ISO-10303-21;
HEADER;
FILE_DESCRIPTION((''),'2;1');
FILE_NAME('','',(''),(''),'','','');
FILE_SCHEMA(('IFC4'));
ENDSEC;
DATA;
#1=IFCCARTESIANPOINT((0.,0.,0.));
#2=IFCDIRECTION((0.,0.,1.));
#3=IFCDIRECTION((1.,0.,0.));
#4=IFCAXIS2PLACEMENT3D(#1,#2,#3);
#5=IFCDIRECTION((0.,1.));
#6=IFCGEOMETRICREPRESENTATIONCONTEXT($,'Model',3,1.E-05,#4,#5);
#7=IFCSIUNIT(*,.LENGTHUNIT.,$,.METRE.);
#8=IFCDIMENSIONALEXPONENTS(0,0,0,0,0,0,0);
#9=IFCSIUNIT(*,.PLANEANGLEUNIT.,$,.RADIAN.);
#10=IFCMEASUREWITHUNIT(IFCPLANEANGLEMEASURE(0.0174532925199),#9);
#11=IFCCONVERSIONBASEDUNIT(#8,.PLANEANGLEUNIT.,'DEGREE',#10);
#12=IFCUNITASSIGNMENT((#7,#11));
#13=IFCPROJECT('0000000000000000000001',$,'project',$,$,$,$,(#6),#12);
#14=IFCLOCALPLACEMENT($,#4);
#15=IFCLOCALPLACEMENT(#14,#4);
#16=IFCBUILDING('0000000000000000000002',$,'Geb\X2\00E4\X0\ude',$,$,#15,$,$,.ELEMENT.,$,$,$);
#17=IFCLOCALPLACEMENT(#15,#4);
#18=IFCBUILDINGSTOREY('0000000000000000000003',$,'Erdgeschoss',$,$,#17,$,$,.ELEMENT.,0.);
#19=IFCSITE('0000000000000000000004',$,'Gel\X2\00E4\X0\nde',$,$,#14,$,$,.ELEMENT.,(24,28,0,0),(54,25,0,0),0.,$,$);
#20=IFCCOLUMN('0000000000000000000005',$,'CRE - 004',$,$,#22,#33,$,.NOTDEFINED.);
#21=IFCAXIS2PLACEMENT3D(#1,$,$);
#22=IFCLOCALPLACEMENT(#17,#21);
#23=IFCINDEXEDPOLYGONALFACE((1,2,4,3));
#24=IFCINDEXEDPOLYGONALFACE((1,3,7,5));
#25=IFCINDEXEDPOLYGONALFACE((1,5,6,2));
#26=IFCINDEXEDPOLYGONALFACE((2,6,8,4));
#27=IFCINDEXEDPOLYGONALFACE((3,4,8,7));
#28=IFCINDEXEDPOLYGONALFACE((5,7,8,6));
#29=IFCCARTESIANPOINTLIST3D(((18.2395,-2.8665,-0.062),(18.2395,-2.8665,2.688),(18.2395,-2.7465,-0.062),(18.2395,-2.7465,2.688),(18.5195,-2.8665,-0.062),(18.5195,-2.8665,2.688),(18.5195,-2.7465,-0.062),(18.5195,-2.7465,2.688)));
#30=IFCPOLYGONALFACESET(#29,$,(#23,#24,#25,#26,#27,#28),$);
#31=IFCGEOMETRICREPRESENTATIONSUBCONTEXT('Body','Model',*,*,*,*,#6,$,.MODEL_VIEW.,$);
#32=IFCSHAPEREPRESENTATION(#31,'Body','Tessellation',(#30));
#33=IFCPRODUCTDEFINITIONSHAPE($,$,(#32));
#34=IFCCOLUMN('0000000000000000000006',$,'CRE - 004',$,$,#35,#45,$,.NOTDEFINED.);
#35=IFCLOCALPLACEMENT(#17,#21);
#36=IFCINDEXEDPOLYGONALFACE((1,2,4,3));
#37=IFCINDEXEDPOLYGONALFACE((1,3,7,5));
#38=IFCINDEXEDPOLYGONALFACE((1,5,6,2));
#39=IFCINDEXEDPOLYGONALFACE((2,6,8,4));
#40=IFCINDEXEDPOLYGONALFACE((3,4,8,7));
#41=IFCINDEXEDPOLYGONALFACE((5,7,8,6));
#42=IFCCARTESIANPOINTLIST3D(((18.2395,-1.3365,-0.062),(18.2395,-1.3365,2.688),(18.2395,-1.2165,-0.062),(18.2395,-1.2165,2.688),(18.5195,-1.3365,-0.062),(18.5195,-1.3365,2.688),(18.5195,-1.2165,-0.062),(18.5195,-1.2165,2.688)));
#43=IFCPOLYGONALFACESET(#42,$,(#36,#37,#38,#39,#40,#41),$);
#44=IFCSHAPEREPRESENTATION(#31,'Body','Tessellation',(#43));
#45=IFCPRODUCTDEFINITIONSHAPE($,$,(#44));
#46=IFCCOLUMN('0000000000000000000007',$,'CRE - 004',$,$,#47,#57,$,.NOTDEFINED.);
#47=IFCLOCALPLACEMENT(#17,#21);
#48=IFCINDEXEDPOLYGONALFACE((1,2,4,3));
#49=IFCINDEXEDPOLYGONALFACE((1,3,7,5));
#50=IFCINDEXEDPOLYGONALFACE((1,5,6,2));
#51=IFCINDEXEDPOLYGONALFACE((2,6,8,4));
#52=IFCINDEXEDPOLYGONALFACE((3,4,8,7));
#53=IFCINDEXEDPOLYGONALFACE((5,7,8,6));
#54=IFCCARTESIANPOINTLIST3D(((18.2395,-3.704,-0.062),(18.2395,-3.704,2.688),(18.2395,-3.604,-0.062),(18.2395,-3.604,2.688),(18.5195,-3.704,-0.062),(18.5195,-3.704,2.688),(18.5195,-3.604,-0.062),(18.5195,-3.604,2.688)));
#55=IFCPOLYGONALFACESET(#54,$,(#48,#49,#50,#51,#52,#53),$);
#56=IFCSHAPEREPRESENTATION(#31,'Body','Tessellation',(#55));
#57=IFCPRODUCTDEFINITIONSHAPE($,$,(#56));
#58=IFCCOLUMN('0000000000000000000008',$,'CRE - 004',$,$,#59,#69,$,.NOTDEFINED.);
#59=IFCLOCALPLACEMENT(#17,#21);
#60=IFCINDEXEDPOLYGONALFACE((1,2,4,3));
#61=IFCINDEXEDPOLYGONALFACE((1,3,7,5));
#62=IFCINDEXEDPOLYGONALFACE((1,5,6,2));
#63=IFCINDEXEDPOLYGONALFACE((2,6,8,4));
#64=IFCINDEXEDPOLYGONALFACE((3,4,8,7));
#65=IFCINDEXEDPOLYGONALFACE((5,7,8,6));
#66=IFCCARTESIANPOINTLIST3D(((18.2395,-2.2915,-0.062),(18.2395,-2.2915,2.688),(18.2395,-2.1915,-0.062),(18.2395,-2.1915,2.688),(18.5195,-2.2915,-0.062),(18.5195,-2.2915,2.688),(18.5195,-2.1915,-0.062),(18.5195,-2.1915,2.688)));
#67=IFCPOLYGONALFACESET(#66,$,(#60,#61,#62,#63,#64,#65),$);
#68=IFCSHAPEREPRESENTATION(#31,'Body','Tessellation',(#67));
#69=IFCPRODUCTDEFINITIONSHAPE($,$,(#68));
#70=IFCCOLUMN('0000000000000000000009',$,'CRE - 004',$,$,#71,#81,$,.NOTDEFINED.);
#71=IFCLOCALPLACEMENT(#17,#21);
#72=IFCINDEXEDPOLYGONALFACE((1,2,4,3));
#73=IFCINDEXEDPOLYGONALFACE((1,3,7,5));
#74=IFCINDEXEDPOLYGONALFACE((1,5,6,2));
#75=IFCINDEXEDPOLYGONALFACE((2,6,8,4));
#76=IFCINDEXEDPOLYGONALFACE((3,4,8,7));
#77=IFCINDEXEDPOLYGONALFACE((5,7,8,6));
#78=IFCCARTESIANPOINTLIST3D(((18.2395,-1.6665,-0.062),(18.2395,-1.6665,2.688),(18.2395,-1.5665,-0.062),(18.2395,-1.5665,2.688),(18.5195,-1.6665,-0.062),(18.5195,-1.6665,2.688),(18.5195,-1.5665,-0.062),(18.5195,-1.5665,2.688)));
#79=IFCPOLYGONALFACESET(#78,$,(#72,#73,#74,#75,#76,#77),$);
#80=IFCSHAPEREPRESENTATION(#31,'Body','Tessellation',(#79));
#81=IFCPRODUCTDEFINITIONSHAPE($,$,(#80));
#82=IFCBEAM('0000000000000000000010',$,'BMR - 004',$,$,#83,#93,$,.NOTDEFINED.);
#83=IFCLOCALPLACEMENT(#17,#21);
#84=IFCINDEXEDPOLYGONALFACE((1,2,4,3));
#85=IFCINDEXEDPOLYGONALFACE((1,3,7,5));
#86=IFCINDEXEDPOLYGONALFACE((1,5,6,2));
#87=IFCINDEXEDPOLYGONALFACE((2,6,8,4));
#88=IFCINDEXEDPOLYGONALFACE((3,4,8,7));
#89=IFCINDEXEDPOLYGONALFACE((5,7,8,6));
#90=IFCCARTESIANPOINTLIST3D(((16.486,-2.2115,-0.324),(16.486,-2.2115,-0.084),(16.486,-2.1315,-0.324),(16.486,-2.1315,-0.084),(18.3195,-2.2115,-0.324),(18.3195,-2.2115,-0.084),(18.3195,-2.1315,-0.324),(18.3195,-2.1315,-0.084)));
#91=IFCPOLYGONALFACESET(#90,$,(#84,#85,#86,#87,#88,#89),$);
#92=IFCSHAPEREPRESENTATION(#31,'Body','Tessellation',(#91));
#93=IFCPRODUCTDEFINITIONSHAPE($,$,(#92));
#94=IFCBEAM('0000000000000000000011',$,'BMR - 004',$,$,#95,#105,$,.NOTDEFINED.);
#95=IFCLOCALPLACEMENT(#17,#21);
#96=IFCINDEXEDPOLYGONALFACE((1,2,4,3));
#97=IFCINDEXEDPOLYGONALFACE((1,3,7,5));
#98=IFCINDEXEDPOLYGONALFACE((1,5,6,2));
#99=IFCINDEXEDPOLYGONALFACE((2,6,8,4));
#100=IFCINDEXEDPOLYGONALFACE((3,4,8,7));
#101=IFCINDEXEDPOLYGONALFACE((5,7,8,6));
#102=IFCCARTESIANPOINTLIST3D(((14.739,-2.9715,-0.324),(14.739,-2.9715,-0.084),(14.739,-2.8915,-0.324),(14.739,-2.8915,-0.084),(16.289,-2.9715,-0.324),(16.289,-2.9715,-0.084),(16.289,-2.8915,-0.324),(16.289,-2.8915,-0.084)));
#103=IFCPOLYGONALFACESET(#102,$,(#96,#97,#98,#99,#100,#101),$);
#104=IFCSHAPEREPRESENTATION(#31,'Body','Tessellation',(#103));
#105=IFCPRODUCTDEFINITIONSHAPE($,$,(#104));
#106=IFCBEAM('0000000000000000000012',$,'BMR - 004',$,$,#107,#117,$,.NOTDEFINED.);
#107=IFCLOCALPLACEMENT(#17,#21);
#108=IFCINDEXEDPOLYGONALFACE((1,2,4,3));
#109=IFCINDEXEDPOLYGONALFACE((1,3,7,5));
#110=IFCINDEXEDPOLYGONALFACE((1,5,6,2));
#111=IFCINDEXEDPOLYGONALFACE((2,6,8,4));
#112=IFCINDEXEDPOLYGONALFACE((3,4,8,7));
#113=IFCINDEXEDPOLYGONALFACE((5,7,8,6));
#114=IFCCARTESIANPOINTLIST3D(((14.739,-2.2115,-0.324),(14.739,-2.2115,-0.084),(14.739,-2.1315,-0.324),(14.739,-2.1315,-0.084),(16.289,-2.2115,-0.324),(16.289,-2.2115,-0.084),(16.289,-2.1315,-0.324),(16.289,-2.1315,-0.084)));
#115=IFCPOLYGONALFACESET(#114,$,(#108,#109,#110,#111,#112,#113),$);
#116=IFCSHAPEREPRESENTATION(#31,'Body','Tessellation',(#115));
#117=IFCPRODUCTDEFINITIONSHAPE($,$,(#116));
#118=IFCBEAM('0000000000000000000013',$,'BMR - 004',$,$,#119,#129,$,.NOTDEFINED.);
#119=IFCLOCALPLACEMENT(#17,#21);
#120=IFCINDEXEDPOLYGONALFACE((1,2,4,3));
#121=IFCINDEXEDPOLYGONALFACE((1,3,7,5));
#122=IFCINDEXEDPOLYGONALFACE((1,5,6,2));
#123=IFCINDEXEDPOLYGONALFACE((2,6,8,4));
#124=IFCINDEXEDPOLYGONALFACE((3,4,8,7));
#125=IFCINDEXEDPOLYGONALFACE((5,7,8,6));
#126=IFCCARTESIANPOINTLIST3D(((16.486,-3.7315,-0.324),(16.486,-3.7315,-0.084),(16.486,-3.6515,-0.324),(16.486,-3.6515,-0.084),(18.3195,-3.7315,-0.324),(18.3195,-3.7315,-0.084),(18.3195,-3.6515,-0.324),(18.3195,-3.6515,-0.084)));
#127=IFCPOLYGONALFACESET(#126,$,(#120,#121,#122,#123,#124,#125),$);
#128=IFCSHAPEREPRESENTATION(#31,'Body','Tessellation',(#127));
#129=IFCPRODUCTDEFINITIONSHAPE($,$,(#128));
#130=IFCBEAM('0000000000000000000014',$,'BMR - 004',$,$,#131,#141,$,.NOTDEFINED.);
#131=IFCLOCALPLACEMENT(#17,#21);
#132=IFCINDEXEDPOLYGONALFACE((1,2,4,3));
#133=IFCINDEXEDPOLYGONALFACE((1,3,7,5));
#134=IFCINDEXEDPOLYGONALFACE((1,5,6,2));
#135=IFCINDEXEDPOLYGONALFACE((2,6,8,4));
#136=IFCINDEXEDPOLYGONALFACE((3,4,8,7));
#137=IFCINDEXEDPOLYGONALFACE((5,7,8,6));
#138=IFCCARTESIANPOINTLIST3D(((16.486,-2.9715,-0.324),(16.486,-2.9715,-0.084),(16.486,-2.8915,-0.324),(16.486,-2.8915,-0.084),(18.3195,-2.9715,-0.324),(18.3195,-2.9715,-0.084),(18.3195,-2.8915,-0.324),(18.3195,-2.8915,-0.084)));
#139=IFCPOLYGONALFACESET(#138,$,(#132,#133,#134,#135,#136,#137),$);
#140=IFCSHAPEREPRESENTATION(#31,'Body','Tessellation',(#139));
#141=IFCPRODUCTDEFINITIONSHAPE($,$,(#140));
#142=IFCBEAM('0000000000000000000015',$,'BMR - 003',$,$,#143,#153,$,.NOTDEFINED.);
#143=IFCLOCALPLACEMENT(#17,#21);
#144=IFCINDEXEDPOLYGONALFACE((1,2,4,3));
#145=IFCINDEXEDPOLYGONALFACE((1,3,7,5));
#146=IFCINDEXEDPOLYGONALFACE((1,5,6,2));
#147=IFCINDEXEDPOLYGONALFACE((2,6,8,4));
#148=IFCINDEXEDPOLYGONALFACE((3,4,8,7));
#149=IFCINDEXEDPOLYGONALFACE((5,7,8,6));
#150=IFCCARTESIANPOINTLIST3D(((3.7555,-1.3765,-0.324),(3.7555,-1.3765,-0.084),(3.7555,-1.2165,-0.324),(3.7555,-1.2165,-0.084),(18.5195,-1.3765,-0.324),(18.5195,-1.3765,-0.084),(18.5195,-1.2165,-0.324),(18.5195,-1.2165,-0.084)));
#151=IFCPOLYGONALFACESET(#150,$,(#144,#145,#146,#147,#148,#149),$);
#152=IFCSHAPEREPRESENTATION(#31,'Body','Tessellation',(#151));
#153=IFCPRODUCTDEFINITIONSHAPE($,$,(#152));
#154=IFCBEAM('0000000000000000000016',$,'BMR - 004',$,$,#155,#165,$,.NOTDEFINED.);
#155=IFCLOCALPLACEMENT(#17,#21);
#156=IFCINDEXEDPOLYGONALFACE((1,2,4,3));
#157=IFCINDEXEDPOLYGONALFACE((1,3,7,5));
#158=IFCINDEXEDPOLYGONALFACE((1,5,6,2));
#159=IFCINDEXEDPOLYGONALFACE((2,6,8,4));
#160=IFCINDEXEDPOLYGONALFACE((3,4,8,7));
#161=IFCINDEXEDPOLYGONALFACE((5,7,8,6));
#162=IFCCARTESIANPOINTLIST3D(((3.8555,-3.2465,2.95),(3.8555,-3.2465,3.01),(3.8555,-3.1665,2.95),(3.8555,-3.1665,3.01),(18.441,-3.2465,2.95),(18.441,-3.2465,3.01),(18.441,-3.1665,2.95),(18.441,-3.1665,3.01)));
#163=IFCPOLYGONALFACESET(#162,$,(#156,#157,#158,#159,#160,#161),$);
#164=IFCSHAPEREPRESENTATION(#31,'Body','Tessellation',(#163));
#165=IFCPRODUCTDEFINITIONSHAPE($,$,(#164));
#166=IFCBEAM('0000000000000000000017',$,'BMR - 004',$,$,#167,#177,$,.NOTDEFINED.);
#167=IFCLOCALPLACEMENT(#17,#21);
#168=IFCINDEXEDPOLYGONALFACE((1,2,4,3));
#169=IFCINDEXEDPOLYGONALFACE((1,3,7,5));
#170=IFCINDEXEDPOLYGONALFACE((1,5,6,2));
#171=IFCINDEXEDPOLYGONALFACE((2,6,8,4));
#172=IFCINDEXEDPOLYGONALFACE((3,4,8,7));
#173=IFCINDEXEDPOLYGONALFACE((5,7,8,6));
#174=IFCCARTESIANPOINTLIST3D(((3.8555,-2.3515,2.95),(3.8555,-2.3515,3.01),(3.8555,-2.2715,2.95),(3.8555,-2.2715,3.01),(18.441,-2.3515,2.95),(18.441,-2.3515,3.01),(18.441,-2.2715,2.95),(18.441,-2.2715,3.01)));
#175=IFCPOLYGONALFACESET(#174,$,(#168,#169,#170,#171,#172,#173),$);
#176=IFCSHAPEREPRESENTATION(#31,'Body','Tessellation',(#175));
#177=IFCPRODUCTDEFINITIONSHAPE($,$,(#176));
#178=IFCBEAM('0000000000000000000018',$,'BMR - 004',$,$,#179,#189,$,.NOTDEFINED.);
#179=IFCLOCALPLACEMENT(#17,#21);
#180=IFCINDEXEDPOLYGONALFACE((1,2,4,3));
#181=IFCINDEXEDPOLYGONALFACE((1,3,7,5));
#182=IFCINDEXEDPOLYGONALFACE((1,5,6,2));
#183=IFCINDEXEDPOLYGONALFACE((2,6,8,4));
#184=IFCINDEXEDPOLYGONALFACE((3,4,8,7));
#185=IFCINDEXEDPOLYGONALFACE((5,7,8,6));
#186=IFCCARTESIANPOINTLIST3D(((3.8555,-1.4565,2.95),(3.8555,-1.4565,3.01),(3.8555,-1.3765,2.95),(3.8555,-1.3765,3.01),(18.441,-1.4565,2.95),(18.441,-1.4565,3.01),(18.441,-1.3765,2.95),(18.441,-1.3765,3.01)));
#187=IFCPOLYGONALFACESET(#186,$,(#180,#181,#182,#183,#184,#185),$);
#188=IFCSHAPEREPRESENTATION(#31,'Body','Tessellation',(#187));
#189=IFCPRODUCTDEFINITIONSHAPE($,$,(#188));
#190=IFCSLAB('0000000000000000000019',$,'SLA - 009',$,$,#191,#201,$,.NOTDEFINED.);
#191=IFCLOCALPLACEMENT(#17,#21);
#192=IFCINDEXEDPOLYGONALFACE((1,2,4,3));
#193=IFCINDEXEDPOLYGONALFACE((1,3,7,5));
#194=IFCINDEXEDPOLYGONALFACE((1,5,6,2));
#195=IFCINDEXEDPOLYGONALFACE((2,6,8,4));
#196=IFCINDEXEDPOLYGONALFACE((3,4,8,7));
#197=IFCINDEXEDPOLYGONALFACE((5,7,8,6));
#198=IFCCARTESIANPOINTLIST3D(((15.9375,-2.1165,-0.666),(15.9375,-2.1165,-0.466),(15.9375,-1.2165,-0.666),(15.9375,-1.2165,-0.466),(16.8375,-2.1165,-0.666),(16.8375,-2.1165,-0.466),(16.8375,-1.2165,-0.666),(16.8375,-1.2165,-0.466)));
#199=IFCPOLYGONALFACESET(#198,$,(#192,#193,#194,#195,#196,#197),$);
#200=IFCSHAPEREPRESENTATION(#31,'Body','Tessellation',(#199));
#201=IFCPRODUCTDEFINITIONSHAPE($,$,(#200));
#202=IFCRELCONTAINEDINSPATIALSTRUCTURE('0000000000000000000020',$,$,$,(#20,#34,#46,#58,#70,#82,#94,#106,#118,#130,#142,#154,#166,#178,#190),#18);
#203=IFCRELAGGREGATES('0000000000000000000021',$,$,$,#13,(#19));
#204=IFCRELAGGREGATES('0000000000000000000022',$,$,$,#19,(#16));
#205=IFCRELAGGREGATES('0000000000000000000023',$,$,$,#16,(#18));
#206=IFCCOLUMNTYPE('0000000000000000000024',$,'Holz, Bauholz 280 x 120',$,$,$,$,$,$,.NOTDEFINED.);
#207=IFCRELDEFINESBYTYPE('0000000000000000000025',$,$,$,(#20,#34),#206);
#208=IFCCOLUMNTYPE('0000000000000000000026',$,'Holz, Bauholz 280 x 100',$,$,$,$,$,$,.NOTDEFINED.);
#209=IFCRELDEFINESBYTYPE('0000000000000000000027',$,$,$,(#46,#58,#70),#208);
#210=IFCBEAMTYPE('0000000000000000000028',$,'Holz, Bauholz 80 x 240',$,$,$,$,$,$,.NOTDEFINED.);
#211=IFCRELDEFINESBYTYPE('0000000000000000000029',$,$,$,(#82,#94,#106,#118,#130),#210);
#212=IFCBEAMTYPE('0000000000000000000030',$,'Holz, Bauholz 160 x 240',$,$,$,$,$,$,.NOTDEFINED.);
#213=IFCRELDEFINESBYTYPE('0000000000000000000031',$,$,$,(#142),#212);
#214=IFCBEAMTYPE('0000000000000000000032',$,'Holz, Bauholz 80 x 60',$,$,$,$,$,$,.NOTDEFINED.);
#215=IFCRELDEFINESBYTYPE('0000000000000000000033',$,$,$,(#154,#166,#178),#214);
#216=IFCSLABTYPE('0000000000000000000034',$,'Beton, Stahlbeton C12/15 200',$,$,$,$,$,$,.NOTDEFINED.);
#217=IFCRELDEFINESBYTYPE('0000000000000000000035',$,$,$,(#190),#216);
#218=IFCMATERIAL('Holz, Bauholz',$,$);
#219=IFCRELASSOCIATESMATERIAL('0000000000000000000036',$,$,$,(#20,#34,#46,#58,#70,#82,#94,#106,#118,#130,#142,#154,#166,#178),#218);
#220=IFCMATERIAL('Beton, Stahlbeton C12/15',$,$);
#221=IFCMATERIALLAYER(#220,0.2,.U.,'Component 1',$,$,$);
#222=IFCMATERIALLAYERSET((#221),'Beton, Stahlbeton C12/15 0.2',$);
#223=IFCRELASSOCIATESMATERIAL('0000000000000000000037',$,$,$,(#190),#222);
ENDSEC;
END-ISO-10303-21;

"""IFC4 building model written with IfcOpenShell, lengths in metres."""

from ifc_helpers import new_model, entity, si_unit, converted_unit, direction, frame, frame_2d, origin_with_axes, origin_2d_with_axis, place, context, subcontext, project, spatial, line, indexed_curve, rectangle, outline, extrude, material, layer, layer_set, layer_usage, type_object, element, save


model = new_model("IFC4")

# Units and contexts
model_context = context("Model", 3, precision=1e-05, world=origin_with_axes(), true_north=direction((0.0, 1.0)))
body_context = subcontext(model_context, "Body", "Model", "MODEL_VIEW")
ifc_project = project(units=[si_unit("LENGTHUNIT", "METRE"), converted_unit("PLANEANGLEUNIT", "DEGREE", entity("IfcPlaneAngleMeasure", 0.0174532925199), si_unit("PLANEANGLEUNIT", "RADIAN"), dimensions=[0, 0, 0, 0, 0, 0, 0])], contexts=[model_context])

# Site, building, storey
site_placement = place(None, origin_with_axes())
site = spatial("IfcSite", under=ifc_project, at=site_placement, Name="Gelände", CompositionType="ELEMENT", RefLatitude=(24, 28, 0, 0), RefLongitude=(54, 25, 0, 0), RefElevation=0.0)
building_placement = place(site_placement, origin_with_axes())
building = spatial("IfcBuilding", under=site, at=building_placement, Name="Gebäude", CompositionType="ELEMENT")
storey_placement = place(building_placement, origin_with_axes())
storey = spatial("IfcBuildingStorey", under=building, at=storey_placement, Name="Erdgeschoss", CompositionType="ELEMENT", Elevation=0.0)

# Columns
ifc_material_1 = material(Name="Holz, Bauholz")
column_type_1 = type_object("IfcColumnType", Name="Holz, Bauholz 280 x 120", PredefinedType="NOTDEFINED")
for number, where, z_axis, x_axis, name in (
    (1, (18.3795, -2.8065, -0.062), (0.0, 0.0, 1.0), (0.0, 1.0, 0.0), "CRE - 004"),
    (2, (18.3795, -1.2765, -0.062), (0.0, 0.0, 1.0), (0.0, 1.0, 0.0), "CRE - 004"),
):
    element("IfcColumn", number, at=place(storey_placement, frame(where, z_axis=z_axis, x_axis=x_axis)), inside=storey, type_object=column_type_1, material=ifc_material_1, Name=name, PredefinedType="NOTDEFINED", context=body_context, shape_type="SweptSolid", body=[
        extrude(rectangle(XDim=0.28, YDim=0.12, at=origin_2d_with_axis()), frame((0.0, 0.0, 0.0), z_axis=(0.0, 0.0, 1.0), x_axis=(0.0, 1.0, 0.0)), (0.0, 0.0, 1.0), 2.75),
    ])
column_type_2 = type_object("IfcColumnType", Name="Holz, Bauholz 280 x 100", PredefinedType="NOTDEFINED")
for number, where, z_axis, x_axis, name in (
    (3, (18.3795, -3.654, -0.062), (0.0, 0.0, 1.0), (0.0, 1.0, 0.0), "CRE - 004"),
    (4, (18.3795, -2.2415, -0.062), (0.0, 0.0, 1.0), (0.0, 1.0, 0.0), "CRE - 004"),
    (5, (18.3795, -1.6165, -0.062), (0.0, 0.0, 1.0), (0.0, 1.0, 0.0), "CRE - 004"),
):
    element("IfcColumn", number, at=place(storey_placement, frame(where, z_axis=z_axis, x_axis=x_axis)), inside=storey, type_object=column_type_2, material=ifc_material_1, Name=name, PredefinedType="NOTDEFINED", context=body_context, shape_type="SweptSolid", body=[
        extrude(rectangle(XDim=0.28, YDim=0.1, at=origin_2d_with_axis()), frame((0.0, 0.0, 0.0), z_axis=(0.0, 0.0, 1.0), x_axis=(0.0, 1.0, 0.0)), (0.0, 0.0, 1.0), 2.75),
    ])

# Beams
beam_type_1 = type_object("IfcBeamType", Name="Holz, Bauholz 80 x 240", PredefinedType="NOTDEFINED")
beam_1_placement = place(storey_placement, frame((18.3195, -2.1715, -0.084), z_axis=(0.0, 0.0, 1.0), x_axis=(0.0, 1.0, 0.0)))
element("IfcBeam", 6, at=beam_1_placement, inside=storey, type_object=beam_type_1, material=ifc_material_1, Name="BMR - 004", PredefinedType="NOTDEFINED", context=body_context, shape_type="SweptSolid", body=[
    extrude(rectangle(XDim=0.24, YDim=0.08, at=frame_2d((-0.12, 0.0), x_axis=(1.0, 0.0))), frame((0.0, 0.0, 0.0), z_axis=(0.0, 1.0, 0.0), x_axis=(0.0, 0.0, 1.0)), (0.0, 0.0, 1.0), 1.8335),
])
for number, where, z_axis, x_axis, name in (
    (7, (16.289, -2.9315, -0.084), (0.0, 0.0, 1.0), (0.0, 1.0, 0.0), "BMR - 004"),
    (8, (16.289, -2.1715, -0.084), (0.0, 0.0, 1.0), (0.0, 1.0, 0.0), "BMR - 004"),
):
    element("IfcBeam", number, at=place(storey_placement, frame(where, z_axis=z_axis, x_axis=x_axis)), inside=storey, type_object=beam_type_1, material=ifc_material_1, Name=name, PredefinedType="NOTDEFINED", context=body_context, shape_type="SweptSolid", body=[
        extrude(rectangle(XDim=0.24, YDim=0.08, at=frame_2d((-0.12, 0.0), x_axis=(1.0, 0.0))), frame((0.0, 0.0, 0.0), z_axis=(0.0, 1.0, 0.0), x_axis=(0.0, 0.0, 1.0)), (0.0, 0.0, 1.0), 1.55),
    ])
for number, where, z_axis, x_axis, name in (
    (9, (18.3195, -3.6915, -0.084), (0.0, 0.0, 1.0), (0.0, 1.0, 0.0), "BMR - 004"),
    (10, (18.3195, -2.9315, -0.084), (0.0, 0.0, 1.0), (0.0, 1.0, 0.0), "BMR - 004"),
):
    element("IfcBeam", number, at=place(storey_placement, frame(where, z_axis=z_axis, x_axis=x_axis)), inside=storey, type_object=beam_type_1, material=ifc_material_1, Name=name, PredefinedType="NOTDEFINED", context=body_context, shape_type="SweptSolid", body=[
        extrude(rectangle(XDim=0.24, YDim=0.08, at=frame_2d((-0.12, 0.0), x_axis=(1.0, 0.0))), frame((0.0, 0.0, 0.0), z_axis=(0.0, 1.0, 0.0), x_axis=(0.0, 0.0, 1.0)), (0.0, 0.0, 1.0), 1.8335),
    ])
beam_type_2 = type_object("IfcBeamType", Name="Holz, Bauholz 160 x 240", PredefinedType="NOTDEFINED")
beam_2_placement = place(storey_placement, frame((18.5195, -1.2965, -0.084), z_axis=(0.0, 0.0, 1.0), x_axis=(0.0, 1.0, 0.0)))
element("IfcBeam", 11, at=beam_2_placement, inside=storey, type_object=beam_type_2, material=ifc_material_1, Name="BMR - 003", PredefinedType="NOTDEFINED", context=body_context, shape_type="SweptSolid", body=[
    extrude(rectangle(XDim=0.24, YDim=0.16, at=frame_2d((-0.12, 0.0), x_axis=(1.0, 0.0))), frame((0.0, 0.0, 0.0), z_axis=(0.0, 1.0, 0.0), x_axis=(0.0, 0.0, 1.0)), (0.0, 0.0, 1.0), 14.764),
])
beam_type_3 = type_object("IfcBeamType", Name="Holz, Bauholz 80 x 60", PredefinedType="NOTDEFINED")
for number, where, z_axis, x_axis, name in (
    (12, (18.441, -3.2065, 3.01), (0.0, 0.0, 1.0), (0.0, 1.0, 0.0), "BMR - 004"),
    (13, (18.441, -2.3115, 3.01), (0.0, 0.0, 1.0), (0.0, 1.0, 0.0), "BMR - 004"),
    (14, (18.441, -1.4165, 3.01), (0.0, 0.0, 1.0), (0.0, 1.0, 0.0), "BMR - 004"),
):
    element("IfcBeam", number, at=place(storey_placement, frame(where, z_axis=z_axis, x_axis=x_axis)), inside=storey, type_object=beam_type_3, material=ifc_material_1, Name=name, PredefinedType="NOTDEFINED", context=body_context, shape_type="SweptSolid", body=[
        extrude(rectangle(XDim=0.06, YDim=0.08, at=frame_2d((-0.03, 0.0), x_axis=(1.0, 0.0))), frame((0.0, 0.0, 0.0), z_axis=(0.0, 1.0, 0.0), x_axis=(0.0, 0.0, 1.0)), (0.0, 0.0, 1.0), 14.5855),
    ])

# Slab
ifc_material_2 = material(Name="Beton, Stahlbeton C12/15")
ifc_layer = layer(ifc_material_2, 0.2, ventilated="UNKNOWN", Name="Component 1")
ifc_layer_set = layer_set([ifc_layer], Name="Beton, Stahlbeton C12/15 0.2")
ifc_layer_usage_1 = layer_usage(ifc_layer_set, "AXIS3", "NEGATIVE", 0.2)
slab_type = type_object("IfcSlabType", Name="Beton, Stahlbeton C12/15 200", PredefinedType="NOTDEFINED")
slab_1_placement = place(storey_placement, frame((15.9375, -2.1165, -0.466), z_axis=(0.0, 0.0, 1.0), x_axis=(1.0, 0.0, 0.0)))
element("IfcSlab", 15, at=slab_1_placement, inside=storey, type_object=slab_type, material=ifc_layer_usage_1, Name="SLA - 009", PredefinedType="NOTDEFINED", context=body_context, shape_type="SweptSolid", body=[
    extrude(outline(indexed_curve([(0.0, 0.0), (0.9, 0.0), (0.9, 0.9), (0.0, 0.9)], segments=[line(1, 2, 3, 4, 1)])), frame((0.0, 0.0, -0.2), z_axis=(0.0, 0.0, 1.0), x_axis=(1.0, 0.0, 0.0)), (0.0, 0.0, 1.0), 0.2),
])

save(model, "model.ifc")
